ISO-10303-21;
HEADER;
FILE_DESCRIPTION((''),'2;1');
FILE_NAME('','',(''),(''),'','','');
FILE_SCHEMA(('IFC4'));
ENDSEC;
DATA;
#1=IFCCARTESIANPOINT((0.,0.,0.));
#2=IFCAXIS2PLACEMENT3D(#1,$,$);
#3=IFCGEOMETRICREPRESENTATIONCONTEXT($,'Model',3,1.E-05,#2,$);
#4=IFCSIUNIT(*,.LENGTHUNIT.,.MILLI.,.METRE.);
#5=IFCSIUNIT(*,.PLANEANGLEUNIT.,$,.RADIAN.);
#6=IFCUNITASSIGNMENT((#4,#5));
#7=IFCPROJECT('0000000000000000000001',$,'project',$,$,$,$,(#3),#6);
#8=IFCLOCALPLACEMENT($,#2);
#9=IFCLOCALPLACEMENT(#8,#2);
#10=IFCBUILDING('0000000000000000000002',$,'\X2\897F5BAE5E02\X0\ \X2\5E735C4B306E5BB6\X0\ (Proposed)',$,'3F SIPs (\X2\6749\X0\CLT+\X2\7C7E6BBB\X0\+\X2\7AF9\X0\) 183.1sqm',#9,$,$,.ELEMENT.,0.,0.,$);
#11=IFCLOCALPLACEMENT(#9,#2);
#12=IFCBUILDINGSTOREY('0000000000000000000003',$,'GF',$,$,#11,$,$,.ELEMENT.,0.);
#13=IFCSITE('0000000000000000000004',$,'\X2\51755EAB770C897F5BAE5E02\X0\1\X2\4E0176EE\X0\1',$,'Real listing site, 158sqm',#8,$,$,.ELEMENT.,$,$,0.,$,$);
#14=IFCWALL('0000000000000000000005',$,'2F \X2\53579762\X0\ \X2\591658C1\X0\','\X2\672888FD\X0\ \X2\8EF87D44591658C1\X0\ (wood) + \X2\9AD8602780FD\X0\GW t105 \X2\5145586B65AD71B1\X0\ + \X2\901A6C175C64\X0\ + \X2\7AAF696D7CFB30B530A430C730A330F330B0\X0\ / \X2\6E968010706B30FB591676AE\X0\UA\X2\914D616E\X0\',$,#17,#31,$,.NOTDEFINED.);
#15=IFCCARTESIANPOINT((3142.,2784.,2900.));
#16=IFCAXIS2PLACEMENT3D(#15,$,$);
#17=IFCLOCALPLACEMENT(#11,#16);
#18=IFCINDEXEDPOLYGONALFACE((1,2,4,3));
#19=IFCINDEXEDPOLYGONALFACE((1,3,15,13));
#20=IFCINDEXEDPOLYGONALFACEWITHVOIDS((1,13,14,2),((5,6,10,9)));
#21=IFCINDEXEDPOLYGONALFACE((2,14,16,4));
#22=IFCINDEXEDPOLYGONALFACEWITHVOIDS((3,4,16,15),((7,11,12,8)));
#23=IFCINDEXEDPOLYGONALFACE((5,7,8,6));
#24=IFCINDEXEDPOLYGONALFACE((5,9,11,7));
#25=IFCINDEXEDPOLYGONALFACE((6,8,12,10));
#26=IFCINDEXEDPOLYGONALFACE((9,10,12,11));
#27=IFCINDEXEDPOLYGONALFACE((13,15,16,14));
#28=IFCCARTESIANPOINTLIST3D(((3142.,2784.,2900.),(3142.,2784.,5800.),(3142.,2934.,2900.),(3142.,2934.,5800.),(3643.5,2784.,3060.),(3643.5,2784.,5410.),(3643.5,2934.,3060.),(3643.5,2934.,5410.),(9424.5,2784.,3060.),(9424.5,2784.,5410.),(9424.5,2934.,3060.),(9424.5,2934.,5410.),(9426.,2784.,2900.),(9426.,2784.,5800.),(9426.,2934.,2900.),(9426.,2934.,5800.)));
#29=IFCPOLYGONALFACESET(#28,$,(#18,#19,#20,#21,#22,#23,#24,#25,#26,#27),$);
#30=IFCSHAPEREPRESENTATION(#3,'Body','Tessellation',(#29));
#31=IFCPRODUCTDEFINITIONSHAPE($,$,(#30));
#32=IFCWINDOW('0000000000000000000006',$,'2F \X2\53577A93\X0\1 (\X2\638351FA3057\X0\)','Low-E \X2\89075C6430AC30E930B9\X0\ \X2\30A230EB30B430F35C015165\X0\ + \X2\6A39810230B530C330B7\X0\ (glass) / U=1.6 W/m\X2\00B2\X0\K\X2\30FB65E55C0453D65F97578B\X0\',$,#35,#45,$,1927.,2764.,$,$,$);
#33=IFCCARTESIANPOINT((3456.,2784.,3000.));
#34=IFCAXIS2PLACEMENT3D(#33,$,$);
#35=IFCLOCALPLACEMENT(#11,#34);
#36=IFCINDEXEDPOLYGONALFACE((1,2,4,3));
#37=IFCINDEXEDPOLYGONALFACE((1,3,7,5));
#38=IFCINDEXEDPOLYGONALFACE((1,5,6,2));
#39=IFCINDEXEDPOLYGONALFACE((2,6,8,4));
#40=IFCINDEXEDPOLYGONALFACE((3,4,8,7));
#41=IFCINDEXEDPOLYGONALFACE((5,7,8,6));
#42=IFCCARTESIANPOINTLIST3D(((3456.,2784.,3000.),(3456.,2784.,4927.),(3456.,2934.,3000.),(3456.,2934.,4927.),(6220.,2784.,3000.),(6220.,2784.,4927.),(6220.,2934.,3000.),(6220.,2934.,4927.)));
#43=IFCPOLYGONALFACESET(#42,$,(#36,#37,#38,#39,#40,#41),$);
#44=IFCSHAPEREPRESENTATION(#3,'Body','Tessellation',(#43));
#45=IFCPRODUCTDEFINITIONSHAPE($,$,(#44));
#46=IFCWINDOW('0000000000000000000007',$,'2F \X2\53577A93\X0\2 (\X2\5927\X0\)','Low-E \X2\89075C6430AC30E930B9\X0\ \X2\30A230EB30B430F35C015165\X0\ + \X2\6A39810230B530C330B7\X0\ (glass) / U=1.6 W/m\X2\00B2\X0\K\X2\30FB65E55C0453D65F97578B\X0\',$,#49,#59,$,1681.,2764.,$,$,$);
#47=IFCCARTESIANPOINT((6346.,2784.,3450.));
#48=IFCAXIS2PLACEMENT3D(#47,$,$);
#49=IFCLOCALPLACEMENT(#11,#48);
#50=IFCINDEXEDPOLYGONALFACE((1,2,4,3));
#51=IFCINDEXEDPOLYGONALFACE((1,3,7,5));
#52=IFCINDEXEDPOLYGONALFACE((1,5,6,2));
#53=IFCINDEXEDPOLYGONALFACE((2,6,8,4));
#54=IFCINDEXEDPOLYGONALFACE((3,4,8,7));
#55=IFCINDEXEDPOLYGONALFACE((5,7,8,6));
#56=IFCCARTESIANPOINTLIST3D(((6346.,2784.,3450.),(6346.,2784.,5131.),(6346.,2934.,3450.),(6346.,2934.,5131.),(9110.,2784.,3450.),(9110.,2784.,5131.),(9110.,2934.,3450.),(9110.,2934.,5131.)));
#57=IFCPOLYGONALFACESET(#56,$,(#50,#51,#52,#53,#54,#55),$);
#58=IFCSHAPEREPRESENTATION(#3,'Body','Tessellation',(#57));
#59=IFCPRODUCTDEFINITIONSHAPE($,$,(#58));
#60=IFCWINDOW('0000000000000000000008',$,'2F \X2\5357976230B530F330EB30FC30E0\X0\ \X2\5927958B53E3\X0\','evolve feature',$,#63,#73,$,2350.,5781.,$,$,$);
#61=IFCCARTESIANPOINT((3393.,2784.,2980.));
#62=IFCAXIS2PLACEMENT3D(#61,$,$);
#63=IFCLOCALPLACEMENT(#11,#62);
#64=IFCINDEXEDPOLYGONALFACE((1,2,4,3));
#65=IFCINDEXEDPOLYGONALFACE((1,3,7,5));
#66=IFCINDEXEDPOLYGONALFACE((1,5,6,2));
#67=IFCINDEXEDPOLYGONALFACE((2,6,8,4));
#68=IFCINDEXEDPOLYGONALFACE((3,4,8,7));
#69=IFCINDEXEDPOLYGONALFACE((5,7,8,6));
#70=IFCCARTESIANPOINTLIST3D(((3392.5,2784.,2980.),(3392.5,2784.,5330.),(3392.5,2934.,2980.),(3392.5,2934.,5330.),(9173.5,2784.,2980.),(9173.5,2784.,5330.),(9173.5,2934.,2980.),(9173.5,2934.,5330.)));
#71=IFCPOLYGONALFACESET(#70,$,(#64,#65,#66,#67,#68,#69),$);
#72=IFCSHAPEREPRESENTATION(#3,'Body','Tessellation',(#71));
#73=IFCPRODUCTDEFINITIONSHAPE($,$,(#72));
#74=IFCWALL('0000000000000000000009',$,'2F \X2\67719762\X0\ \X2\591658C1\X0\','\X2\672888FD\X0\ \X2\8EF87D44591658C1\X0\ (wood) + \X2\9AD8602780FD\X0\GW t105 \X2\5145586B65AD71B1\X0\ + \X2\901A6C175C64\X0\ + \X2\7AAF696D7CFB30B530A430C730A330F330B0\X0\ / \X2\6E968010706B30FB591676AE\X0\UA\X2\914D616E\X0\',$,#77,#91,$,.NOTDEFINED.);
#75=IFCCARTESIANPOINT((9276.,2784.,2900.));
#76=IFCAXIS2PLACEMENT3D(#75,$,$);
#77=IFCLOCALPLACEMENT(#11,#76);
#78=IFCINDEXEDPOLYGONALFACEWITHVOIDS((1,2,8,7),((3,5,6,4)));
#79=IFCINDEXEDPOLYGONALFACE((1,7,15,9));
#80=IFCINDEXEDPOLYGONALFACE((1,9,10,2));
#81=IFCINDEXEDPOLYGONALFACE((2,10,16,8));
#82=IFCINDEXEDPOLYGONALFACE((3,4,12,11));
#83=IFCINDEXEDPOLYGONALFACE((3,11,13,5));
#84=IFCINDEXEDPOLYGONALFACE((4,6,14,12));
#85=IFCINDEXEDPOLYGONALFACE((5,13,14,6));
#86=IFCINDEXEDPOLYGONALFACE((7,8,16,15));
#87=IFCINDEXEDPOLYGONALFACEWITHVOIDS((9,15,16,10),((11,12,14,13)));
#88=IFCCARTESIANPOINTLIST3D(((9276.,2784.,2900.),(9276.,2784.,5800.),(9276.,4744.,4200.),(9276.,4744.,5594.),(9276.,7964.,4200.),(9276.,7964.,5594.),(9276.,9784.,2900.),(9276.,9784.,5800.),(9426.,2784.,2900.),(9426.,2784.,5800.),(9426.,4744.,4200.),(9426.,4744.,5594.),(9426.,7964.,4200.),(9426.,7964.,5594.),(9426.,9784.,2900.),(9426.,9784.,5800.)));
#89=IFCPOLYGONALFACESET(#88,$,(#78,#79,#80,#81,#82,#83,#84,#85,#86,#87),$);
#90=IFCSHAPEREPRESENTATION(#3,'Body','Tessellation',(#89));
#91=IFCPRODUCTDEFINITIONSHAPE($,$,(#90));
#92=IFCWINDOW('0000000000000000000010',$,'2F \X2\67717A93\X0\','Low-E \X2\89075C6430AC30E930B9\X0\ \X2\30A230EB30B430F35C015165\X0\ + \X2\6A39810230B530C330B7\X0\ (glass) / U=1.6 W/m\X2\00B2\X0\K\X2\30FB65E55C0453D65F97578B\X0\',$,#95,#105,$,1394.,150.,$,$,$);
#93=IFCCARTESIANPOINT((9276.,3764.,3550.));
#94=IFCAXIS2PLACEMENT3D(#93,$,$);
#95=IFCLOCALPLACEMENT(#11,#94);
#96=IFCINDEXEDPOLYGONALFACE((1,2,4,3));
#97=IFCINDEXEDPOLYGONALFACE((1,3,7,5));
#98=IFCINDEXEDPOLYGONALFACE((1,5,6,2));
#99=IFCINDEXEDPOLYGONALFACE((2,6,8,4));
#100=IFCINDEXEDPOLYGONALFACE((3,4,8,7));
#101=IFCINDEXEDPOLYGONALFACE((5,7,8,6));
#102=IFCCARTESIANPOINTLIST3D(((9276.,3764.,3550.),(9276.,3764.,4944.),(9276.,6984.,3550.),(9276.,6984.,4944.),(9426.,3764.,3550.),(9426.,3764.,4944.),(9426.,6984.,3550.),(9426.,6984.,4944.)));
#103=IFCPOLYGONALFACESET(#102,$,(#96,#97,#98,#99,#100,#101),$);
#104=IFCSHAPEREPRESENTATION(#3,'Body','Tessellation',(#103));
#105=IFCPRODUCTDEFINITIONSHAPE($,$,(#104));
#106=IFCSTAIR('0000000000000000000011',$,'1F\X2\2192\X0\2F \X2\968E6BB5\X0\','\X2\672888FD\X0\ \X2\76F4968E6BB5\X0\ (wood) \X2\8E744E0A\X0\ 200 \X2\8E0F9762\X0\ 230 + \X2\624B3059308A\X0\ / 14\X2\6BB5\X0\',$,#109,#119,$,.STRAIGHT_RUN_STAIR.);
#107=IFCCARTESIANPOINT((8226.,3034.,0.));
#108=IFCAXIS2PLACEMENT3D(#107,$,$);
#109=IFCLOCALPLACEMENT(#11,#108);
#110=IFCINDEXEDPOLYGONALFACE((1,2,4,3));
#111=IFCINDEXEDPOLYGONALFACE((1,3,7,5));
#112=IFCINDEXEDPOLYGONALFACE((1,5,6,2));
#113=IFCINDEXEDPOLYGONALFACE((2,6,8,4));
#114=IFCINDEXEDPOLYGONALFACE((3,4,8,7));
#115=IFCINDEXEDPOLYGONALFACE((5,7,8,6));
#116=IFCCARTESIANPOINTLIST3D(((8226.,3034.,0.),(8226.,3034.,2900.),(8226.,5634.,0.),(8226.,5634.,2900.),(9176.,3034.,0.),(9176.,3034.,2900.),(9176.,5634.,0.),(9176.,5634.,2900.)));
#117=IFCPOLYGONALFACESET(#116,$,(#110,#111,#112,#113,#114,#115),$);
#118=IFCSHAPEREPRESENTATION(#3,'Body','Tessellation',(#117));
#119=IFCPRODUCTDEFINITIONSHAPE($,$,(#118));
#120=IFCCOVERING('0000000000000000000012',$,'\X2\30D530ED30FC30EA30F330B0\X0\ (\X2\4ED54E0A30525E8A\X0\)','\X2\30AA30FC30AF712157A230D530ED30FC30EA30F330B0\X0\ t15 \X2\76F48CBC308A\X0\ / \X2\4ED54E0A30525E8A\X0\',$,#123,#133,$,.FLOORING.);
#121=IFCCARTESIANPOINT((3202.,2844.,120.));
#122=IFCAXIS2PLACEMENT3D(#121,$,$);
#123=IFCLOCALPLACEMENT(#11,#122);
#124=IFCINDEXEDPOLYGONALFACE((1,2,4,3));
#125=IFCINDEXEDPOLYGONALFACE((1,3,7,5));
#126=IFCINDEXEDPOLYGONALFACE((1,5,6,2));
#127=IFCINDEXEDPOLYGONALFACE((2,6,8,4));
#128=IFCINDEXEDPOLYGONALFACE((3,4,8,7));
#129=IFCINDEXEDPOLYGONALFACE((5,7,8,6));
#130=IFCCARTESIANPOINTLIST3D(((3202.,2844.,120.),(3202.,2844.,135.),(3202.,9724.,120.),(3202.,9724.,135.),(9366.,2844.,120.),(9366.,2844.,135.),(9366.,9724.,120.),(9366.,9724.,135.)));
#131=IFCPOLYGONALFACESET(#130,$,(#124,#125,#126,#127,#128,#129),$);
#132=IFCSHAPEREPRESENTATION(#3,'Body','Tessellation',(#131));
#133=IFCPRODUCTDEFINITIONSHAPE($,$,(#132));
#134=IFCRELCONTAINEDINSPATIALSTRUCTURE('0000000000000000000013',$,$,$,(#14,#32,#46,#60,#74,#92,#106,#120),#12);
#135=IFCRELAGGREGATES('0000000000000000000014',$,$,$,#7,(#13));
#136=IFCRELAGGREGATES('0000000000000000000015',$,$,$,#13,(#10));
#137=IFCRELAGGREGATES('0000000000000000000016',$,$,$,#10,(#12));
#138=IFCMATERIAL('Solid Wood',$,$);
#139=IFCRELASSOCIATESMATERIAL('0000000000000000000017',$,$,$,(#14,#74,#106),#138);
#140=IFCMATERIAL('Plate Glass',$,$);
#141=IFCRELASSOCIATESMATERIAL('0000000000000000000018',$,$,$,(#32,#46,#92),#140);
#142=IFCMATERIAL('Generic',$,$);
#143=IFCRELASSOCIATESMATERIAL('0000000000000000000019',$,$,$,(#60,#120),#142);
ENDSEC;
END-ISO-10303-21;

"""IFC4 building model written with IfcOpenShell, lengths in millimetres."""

from ifc_helpers import new_model, si_unit, frame, frame_2d, origin, place, context, project, spatial, rectangle, extrude, material, element, fill, save


model = new_model("IFC4")

# Units and contexts
model_context = context("Model", 3, precision=1e-05, world=origin())
ifc_project = project(units=[si_unit("LENGTHUNIT", "METRE", prefix="MILLI"), si_unit("PLANEANGLEUNIT", "RADIAN")], contexts=[model_context])

# Site, building, storey
site_placement = place(None, origin())
site = spatial("IfcSite", under=ifc_project, at=site_placement, Name="兵庫県西宮市1丁目1", ObjectType="Real listing site, 158sqm", CompositionType="ELEMENT", RefElevation=0.0)
building_placement = place(site_placement, origin())
building = spatial("IfcBuilding", under=site, at=building_placement, Name="西宮市 平屋の家 (Proposed)", ObjectType="3F SIPs (杉CLT+籾殻+竹) 183.1sqm", CompositionType="ELEMENT", ElevationOfRefHeight=0.0, ElevationOfTerrain=0.0)
storey_placement = place(building_placement, origin())
storey = spatial("IfcBuildingStorey", under=building, at=storey_placement, Name="GF", CompositionType="ELEMENT", Elevation=0.0)

# Shared definitions
ifc_material_1 = material(Name="Solid Wood")

# Shared definitions
ifc_material_2 = material(Name="Plate Glass")
ifc_material_3 = material(Name="Generic")

# Wall, openings, windows
wall_1_placement = place(storey_placement, frame((3142.0, 2784.0, 2900.0)))
wall_1 = element("IfcWall", 1, at=wall_1_placement, inside=storey, material=ifc_material_1, Name="2F 南面 外壁", Description="木製 軸組外壁 (wood) + 高性能GW t105 充填断熱 + 通気層 + 窯業系サイディング / 準耐火・外皮UA配慮", PredefinedType="NOTDEFINED", context=model_context, shape_type="SweptSolid", body=[
    extrude(rectangle(XDim=6284.0, YDim=150.0, at=frame_2d((3142.0, 75.0))), frame((3142.0, 2784.0, 2900.0)), (0.0, 0.0, 1.0), 2900.0),
])
opening_1_placement = place(storey_placement, frame((3456.0, 2784.0, 3000.0)))
opening_1 = element("IfcOpeningElement", 2, at=opening_1_placement, cuts=wall_1, PredefinedType="NOTDEFINED", context=model_context, shape_type="SweptSolid", body=[
    extrude(rectangle(XDim=2764.0, YDim=150.0, at=frame_2d((1382.0, 75.0))), frame((3456.0, 2784.0, 3000.0)), (0.0, 0.0, 1.0), 1927.0),
])
opening_2_placement = place(storey_placement, frame((6346.0, 2784.0, 3450.0)))
opening_2 = element("IfcOpeningElement", 3, at=opening_2_placement, cuts=wall_1, PredefinedType="NOTDEFINED", context=model_context, shape_type="SweptSolid", body=[
    extrude(rectangle(XDim=2764.0, YDim=150.0, at=frame_2d((1382.0, 75.0))), frame((6346.0, 2784.0, 3450.0)), (0.0, 0.0, 1.0), 1681.0),
])
opening_3_placement = place(storey_placement, frame((3393.0, 2784.0, 2980.0)))
opening_3 = element("IfcOpeningElement", 4, at=opening_3_placement, cuts=wall_1, PredefinedType="NOTDEFINED", context=model_context, shape_type="SweptSolid", body=[
    extrude(rectangle(XDim=5781.0, YDim=150.0, at=frame_2d((2890.0, 75.0))), frame((3393.0, 2784.0, 2980.0)), (0.0, 0.0, 1.0), 2350.0),
])
window_1_placement = place(storey_placement, frame((3456.0, 2784.0, 3000.0)))
window_1 = element("IfcWindow", 5, at=window_1_placement, inside=storey, material=ifc_material_2, Name="2F 南窓1 (掃出し)", Description="Low-E 複層ガラス アルゴン封入 + 樹脂サッシ (glass) / U=1.6 W/m²K・日射取得型", OverallHeight=1927.0, OverallWidth=2764.0, context=model_context, shape_type="SweptSolid", body=[
    extrude(rectangle(XDim=2764.0, YDim=150.0, at=frame_2d((1382.0, 75.0))), frame((3456.0, 2784.0, 3000.0)), (0.0, 0.0, 1.0), 1927.0),
])
fill(opening_1, window_1)
window_2_placement = place(storey_placement, frame((6346.0, 2784.0, 3450.0)))
window_2 = element("IfcWindow", 6, at=window_2_placement, inside=storey, material=ifc_material_2, Name="2F 南窓2 (大)", Description="Low-E 複層ガラス アルゴン封入 + 樹脂サッシ (glass) / U=1.6 W/m²K・日射取得型", OverallHeight=1681.0, OverallWidth=2764.0, context=model_context, shape_type="SweptSolid", body=[
    extrude(rectangle(XDim=2764.0, YDim=150.0, at=frame_2d((1382.0, 75.0))), frame((6346.0, 2784.0, 3450.0)), (0.0, 0.0, 1.0), 1681.0),
])
fill(opening_2, window_2)
window_3_placement = place(storey_placement, frame((3393.0, 2784.0, 2980.0)))
window_3 = element("IfcWindow", 7, at=window_3_placement, inside=storey, material=ifc_material_3, Name="2F 南面サンルーム 大開口", Description="evolve feature", OverallHeight=2350.0, OverallWidth=5781.0, context=model_context, shape_type="SweptSolid", body=[
    extrude(rectangle(XDim=5781.0, YDim=150.0, at=frame_2d((2890.0, 75.0))), frame((3393.0, 2784.0, 2980.0)), (0.0, 0.0, 1.0), 2350.0),
])
fill(opening_3, window_3)

# Wall, opening, window
wall_2_placement = place(storey_placement, frame((9276.0, 2784.0, 2900.0)))
wall_2 = element("IfcWall", 8, at=wall_2_placement, inside=storey, material=ifc_material_1, Name="2F 東面 外壁", Description="木製 軸組外壁 (wood) + 高性能GW t105 充填断熱 + 通気層 + 窯業系サイディング / 準耐火・外皮UA配慮", PredefinedType="NOTDEFINED", context=model_context, shape_type="SweptSolid", body=[
    extrude(rectangle(XDim=150.0, YDim=7000.0, at=frame_2d((75.0, 3500.0))), frame((9276.0, 2784.0, 2900.0)), (0.0, 0.0, 1.0), 2900.0),
])
opening_4_placement = place(storey_placement, frame((9276.0, 3764.0, 3550.0)))
opening_4 = element("IfcOpeningElement", 9, at=opening_4_placement, cuts=wall_2, PredefinedType="NOTDEFINED", context=model_context, shape_type="SweptSolid", body=[
    extrude(rectangle(XDim=150.0, YDim=3220.0, at=frame_2d((75.0, 1610.0))), frame((9276.0, 3764.0, 3550.0)), (0.0, 0.0, 1.0), 1394.0),
])
window_4_placement = place(storey_placement, frame((9276.0, 3764.0, 3550.0)))
window_4 = element("IfcWindow", 10, at=window_4_placement, inside=storey, material=ifc_material_2, Name="2F 東窓", Description="Low-E 複層ガラス アルゴン封入 + 樹脂サッシ (glass) / U=1.6 W/m²K・日射取得型", OverallHeight=1394.0, OverallWidth=150.0, context=model_context, shape_type="SweptSolid", body=[
    extrude(rectangle(XDim=150.0, YDim=3220.0, at=frame_2d((75.0, 1610.0))), frame((9276.0, 3764.0, 3550.0)), (0.0, 0.0, 1.0), 1394.0),
])
fill(opening_4, window_4)

# Stair
stair_placement = place(storey_placement, frame((8226.0, 3034.0, 0.0)))
element("IfcStair", 11, at=stair_placement, inside=storey, material=ifc_material_1, Name="1F→2F 階段", Description="木製 直階段 (wood) 蹴上 200 踏面 230 + 手すり / 14段", PredefinedType="STRAIGHT_RUN_STAIR", context=model_context, shape_type="SweptSolid", body=[
    extrude(rectangle(XDim=950.0, YDim=2600.0, at=frame_2d((475.0, 1300.0))), frame((8226.0, 3034.0, 0.0)), (0.0, 0.0, 1.0), 2900.0),
])

# Covering
covering_placement = place(storey_placement, frame((3202.0, 2844.0, 120.0)))
element("IfcCovering", 12, at=covering_placement, inside=storey, material=ifc_material_3, Name="フローリング (仕上げ床)", Description="オーク無垢フローリング t15 直貼り / 仕上げ床", PredefinedType="FLOORING", context=model_context, shape_type="SweptSolid", body=[
    extrude(rectangle(XDim=6164.0, YDim=6880.0, at=frame_2d((3082.0, 3440.0))), frame((3202.0, 2844.0, 120.0)), (0.0, 0.0, 1.0), 15.0),
])

save(model, "model.ifc")
